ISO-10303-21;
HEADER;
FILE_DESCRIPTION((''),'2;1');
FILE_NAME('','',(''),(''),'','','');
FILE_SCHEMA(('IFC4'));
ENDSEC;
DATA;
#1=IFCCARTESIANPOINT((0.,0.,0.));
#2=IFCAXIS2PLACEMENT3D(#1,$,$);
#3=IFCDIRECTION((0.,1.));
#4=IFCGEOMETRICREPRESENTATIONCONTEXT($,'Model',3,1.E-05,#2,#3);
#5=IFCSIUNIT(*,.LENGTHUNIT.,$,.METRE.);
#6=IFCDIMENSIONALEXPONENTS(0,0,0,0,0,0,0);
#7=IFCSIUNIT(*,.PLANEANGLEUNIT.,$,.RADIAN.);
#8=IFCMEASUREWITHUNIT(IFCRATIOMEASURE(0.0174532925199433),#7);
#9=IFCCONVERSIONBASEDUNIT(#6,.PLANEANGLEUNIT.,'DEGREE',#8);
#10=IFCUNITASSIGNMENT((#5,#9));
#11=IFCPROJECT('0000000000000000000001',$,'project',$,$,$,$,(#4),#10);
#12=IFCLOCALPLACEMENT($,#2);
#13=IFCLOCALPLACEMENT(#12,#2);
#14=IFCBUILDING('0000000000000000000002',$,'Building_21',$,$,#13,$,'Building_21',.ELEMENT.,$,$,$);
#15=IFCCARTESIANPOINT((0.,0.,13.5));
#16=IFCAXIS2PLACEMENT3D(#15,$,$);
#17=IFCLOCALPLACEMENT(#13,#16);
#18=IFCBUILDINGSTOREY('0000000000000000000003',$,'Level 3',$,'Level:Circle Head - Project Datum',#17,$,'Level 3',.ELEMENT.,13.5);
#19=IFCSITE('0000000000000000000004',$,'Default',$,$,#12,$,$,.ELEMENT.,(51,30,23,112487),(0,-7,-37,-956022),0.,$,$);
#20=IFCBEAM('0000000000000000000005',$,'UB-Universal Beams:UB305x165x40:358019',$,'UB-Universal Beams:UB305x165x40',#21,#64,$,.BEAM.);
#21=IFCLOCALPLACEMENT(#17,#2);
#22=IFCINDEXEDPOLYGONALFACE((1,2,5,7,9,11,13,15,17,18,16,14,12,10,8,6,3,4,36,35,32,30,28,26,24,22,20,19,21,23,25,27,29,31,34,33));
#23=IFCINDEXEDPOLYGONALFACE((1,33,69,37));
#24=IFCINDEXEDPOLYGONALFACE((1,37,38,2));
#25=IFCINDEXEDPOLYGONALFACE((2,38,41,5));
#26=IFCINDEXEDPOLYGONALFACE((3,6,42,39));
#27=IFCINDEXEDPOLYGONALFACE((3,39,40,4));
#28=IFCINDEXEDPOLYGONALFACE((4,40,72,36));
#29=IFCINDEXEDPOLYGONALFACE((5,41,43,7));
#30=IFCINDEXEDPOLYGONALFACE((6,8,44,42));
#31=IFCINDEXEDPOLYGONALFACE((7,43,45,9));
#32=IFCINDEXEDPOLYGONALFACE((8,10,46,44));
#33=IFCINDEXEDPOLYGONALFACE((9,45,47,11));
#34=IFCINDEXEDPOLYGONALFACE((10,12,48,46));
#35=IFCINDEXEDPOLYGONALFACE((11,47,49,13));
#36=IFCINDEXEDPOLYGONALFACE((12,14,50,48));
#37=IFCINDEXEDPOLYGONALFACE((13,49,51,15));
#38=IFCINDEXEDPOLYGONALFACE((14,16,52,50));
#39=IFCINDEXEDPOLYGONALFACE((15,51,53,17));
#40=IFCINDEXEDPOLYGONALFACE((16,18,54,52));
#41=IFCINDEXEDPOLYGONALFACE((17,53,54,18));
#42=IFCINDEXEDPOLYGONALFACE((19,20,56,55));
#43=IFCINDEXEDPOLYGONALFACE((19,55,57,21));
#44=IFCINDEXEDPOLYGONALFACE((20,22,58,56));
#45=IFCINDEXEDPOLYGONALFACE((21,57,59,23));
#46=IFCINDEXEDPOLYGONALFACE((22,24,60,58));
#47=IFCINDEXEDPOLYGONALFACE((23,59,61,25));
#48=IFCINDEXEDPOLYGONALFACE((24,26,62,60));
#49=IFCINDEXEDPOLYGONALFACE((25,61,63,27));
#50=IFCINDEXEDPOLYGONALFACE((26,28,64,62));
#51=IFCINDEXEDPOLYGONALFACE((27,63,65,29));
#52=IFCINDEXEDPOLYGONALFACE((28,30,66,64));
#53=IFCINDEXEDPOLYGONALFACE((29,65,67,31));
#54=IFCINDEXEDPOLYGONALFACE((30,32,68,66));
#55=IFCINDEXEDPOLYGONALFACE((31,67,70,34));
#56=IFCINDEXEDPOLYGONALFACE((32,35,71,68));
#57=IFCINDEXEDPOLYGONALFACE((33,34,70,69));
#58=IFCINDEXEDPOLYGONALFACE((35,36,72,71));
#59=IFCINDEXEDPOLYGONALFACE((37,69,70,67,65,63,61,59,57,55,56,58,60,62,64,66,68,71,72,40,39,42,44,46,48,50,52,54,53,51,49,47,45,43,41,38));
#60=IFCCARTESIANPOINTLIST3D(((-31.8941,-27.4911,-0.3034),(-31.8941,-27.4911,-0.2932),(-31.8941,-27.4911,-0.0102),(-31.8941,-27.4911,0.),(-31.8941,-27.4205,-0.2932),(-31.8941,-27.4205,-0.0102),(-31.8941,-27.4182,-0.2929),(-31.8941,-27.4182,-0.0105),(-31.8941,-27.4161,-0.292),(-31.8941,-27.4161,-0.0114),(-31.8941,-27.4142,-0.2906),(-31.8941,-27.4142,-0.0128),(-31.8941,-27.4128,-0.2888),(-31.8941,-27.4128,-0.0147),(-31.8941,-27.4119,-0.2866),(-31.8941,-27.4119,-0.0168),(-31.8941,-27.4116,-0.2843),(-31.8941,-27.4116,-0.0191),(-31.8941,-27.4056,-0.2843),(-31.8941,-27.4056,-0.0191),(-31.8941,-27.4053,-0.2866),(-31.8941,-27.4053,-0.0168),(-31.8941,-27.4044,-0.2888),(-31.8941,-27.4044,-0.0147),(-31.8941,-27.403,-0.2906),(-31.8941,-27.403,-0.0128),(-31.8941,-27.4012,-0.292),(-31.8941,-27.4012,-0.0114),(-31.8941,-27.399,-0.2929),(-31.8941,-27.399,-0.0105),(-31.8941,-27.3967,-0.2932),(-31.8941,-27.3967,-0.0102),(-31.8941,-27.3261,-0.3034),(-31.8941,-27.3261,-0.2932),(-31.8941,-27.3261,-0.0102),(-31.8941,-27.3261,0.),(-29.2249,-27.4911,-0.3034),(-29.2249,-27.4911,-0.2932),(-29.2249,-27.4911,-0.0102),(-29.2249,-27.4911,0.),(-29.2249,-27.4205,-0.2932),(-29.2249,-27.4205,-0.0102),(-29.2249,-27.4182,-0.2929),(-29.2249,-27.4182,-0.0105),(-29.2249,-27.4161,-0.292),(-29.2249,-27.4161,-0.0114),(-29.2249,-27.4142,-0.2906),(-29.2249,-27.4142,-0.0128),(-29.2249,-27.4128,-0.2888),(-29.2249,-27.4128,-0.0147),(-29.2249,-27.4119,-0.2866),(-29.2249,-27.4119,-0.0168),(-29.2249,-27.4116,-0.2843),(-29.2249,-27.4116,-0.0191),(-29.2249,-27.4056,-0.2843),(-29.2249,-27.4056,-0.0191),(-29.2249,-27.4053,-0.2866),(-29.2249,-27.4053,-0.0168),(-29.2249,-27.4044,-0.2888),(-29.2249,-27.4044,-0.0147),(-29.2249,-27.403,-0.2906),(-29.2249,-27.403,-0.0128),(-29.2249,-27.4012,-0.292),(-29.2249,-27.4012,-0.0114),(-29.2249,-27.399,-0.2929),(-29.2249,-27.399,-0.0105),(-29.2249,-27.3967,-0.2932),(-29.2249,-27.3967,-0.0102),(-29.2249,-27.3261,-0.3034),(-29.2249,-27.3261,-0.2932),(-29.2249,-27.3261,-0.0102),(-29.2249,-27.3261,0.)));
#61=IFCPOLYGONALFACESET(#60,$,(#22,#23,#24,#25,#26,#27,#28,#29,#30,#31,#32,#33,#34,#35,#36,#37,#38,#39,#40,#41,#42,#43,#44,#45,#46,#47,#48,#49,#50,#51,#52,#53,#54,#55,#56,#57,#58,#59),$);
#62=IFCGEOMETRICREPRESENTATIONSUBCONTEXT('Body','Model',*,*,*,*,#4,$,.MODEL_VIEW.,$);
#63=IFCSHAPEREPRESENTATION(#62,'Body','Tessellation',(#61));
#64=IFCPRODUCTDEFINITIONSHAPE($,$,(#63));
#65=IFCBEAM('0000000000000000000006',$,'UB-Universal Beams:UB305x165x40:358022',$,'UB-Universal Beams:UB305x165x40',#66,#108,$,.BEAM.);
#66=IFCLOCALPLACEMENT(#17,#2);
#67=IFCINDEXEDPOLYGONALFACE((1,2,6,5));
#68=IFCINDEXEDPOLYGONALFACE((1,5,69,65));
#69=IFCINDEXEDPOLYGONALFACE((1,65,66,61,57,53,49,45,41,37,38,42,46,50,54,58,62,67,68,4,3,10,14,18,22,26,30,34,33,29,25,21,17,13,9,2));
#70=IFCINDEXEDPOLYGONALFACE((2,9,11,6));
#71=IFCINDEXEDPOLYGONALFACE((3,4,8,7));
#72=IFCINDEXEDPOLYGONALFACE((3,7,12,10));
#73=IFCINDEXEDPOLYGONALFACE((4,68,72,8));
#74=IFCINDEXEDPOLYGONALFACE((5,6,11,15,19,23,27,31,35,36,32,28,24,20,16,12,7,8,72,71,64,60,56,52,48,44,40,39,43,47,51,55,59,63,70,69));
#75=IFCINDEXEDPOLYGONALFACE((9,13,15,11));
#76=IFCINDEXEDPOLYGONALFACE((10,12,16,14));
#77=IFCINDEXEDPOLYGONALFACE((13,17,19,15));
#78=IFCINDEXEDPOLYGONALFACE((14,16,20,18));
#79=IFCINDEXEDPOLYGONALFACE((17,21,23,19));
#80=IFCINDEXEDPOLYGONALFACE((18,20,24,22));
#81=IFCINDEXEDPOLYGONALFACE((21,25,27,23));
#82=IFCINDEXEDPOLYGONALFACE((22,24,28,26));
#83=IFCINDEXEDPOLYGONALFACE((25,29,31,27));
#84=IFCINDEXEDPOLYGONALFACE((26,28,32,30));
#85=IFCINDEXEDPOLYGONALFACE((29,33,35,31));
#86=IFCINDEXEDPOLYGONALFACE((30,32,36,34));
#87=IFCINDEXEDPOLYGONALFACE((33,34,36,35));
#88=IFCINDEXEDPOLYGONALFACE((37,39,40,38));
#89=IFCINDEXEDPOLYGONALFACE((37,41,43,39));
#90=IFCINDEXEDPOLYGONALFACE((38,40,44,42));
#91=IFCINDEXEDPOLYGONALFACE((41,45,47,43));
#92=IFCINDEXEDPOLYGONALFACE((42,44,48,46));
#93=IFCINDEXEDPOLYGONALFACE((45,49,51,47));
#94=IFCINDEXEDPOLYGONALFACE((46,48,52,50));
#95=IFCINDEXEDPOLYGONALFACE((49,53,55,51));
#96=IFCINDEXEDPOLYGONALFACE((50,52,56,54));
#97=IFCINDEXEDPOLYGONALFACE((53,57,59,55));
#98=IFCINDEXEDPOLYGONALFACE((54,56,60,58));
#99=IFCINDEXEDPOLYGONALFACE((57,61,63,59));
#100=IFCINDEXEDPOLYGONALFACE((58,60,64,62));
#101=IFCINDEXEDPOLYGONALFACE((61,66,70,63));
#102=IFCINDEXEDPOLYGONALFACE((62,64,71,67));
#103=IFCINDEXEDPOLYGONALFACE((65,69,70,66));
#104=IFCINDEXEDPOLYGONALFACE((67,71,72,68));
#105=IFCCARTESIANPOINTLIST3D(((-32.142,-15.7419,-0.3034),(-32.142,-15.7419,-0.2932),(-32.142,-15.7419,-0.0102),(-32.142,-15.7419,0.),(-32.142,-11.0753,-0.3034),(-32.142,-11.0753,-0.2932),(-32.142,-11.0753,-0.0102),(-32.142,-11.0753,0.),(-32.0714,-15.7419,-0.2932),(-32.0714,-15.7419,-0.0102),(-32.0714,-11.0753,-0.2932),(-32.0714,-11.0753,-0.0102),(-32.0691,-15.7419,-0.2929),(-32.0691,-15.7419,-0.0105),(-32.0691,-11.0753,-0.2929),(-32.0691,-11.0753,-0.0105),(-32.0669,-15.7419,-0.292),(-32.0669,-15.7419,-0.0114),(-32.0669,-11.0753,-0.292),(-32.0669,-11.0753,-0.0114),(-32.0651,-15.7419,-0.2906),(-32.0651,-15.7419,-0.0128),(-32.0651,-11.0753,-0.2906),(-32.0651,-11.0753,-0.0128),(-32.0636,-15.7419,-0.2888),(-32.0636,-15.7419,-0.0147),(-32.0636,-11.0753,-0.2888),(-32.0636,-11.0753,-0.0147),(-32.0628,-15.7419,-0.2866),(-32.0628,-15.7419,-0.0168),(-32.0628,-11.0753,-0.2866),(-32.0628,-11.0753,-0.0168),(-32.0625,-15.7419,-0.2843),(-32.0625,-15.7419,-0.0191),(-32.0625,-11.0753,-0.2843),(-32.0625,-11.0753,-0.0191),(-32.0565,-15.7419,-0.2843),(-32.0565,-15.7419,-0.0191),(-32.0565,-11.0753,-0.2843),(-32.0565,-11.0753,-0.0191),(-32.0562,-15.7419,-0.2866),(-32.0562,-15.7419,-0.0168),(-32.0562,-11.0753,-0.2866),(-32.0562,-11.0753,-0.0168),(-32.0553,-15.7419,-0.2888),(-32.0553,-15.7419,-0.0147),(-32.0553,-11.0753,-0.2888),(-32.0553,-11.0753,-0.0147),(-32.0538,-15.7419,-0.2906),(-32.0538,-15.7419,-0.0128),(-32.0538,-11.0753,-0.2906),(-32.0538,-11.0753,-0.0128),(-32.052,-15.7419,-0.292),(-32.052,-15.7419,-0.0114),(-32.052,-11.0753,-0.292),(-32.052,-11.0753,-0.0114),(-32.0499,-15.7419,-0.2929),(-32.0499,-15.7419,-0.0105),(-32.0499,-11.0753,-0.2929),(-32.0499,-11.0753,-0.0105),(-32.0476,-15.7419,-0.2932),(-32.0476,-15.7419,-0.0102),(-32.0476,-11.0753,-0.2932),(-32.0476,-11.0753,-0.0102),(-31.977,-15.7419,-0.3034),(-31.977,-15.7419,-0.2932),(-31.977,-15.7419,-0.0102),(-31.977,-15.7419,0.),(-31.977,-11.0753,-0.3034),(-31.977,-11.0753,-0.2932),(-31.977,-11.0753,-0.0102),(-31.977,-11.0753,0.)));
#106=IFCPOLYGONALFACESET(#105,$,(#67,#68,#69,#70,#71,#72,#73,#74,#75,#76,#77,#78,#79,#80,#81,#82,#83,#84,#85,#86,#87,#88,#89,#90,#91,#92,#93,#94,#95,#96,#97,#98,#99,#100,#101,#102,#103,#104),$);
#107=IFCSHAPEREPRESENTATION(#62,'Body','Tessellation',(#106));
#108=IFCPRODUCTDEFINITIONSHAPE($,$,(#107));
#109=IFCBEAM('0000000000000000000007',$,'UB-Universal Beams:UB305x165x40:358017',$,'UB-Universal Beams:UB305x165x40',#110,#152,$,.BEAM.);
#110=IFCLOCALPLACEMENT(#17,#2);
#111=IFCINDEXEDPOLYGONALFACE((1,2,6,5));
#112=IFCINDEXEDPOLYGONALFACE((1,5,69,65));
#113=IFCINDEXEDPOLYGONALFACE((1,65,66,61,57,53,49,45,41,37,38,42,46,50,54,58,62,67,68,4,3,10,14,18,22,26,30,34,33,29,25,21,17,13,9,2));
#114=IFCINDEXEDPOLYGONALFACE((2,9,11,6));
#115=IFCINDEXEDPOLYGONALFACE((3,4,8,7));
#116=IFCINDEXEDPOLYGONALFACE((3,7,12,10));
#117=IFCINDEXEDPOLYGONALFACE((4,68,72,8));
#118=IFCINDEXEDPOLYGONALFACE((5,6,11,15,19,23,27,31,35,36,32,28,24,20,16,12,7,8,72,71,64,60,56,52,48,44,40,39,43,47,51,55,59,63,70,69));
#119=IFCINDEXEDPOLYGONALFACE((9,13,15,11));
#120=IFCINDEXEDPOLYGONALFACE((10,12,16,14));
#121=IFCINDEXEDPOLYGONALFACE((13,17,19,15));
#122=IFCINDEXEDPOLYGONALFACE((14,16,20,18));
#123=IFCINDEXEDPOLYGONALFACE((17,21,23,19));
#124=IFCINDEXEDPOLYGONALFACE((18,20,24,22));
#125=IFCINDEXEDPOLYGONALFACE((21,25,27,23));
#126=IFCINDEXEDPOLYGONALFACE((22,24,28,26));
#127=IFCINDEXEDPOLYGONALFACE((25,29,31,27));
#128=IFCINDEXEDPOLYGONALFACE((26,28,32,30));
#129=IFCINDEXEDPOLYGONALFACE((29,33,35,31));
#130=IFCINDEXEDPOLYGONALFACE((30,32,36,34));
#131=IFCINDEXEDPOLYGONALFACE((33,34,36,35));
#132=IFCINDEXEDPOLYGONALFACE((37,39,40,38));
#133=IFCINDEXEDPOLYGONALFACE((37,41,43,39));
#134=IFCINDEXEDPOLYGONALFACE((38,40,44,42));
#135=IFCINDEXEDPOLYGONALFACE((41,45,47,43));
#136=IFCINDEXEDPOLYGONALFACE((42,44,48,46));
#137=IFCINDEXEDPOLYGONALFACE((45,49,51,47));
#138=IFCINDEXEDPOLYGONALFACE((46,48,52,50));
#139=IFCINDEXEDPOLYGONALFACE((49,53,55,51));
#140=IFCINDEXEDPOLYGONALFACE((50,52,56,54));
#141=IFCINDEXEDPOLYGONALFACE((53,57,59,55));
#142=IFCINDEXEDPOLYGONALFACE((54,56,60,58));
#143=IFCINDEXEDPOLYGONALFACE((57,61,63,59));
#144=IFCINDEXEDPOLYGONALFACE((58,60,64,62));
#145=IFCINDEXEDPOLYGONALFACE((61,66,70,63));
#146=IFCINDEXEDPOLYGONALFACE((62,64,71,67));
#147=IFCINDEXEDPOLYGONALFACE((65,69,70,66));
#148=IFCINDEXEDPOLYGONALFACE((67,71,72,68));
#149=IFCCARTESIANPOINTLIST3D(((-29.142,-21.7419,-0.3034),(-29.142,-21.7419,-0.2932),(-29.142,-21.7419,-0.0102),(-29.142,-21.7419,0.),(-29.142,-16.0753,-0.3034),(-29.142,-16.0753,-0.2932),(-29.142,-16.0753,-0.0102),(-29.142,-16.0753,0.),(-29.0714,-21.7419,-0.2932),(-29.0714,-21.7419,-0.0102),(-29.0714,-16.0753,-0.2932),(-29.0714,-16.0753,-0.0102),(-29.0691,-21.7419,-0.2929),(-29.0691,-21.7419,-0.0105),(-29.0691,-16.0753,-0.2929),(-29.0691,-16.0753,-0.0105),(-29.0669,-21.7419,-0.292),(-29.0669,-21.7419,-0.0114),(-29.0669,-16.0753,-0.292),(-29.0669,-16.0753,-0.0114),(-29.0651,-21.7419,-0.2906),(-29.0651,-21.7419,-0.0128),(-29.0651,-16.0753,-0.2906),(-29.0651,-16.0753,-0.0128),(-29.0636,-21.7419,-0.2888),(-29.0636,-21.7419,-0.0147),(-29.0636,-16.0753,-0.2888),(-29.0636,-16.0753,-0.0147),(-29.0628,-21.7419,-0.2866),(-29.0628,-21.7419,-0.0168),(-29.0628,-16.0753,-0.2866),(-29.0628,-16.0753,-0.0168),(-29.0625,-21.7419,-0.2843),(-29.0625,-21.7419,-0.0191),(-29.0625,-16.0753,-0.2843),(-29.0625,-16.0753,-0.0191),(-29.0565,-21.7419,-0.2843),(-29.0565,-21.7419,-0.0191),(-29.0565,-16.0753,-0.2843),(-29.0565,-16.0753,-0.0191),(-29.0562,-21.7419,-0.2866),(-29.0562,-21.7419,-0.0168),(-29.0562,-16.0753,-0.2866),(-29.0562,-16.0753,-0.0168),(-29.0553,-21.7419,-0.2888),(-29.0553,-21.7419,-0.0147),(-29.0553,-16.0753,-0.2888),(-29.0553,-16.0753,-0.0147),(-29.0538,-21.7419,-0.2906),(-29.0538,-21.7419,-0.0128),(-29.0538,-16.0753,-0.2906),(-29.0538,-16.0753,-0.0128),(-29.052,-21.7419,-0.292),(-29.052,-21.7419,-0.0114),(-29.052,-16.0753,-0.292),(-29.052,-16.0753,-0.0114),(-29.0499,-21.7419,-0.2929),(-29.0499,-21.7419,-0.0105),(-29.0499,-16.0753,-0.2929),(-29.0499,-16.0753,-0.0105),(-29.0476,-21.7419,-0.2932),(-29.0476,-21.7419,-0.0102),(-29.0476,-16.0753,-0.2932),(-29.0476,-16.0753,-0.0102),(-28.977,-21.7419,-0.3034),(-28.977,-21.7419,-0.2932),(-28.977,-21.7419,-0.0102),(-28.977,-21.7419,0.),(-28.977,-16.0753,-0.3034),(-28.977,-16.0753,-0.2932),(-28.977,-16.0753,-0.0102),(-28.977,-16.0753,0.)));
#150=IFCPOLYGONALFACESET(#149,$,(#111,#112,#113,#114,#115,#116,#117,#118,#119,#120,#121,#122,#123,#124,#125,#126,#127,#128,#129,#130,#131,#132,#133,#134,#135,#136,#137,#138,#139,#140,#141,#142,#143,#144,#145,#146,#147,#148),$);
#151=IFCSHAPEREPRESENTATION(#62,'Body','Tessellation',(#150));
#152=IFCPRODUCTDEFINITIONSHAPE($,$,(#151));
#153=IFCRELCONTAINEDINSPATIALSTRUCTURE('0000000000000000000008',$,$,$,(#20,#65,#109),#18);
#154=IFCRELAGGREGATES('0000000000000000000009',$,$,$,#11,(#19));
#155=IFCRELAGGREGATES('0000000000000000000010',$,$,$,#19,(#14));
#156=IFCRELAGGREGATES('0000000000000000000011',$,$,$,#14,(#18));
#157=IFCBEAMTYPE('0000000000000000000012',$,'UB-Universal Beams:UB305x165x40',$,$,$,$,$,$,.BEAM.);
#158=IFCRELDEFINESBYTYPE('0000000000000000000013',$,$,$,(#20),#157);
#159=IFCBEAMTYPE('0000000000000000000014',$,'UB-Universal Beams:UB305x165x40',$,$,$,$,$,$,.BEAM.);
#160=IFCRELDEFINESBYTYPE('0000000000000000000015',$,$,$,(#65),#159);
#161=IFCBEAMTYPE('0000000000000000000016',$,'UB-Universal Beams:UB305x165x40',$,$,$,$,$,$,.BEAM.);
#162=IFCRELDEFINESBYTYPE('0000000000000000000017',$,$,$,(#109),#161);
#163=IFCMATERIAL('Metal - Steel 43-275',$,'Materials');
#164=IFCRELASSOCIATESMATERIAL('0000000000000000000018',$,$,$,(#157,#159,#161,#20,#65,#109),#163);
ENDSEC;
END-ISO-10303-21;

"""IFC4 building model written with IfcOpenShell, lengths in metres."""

from ifc_helpers import new_model, entity, si_unit, converted_unit, direction, frame, frame_2d, origin, place, context, subcontext, project, spatial, polyline, circle_curve, parameter, trimmed, segment, composite_curve, i_section, outline, extrude, source, transform, mapped, material, material_profile, profile_set, profile_usage, type_object, type_shapes, element, save


model = new_model("IFC4")

# Units and contexts
model_context = context("Model", 3, precision=1e-05, world=origin(), true_north=direction((0.0, 1.0)))
body_context = subcontext(model_context, "Body", "Model", "MODEL_VIEW")
ifc_project = project(units=[si_unit("LENGTHUNIT", "METRE"), converted_unit("PLANEANGLEUNIT", "DEGREE", entity("IfcRatioMeasure", 0.0174532925199433), si_unit("PLANEANGLEUNIT", "RADIAN"), dimensions=[0, 0, 0, 0, 0, 0, 0])], contexts=[model_context])

# Site, building, storey
site_placement = place(None, origin())
site = spatial("IfcSite", under=ifc_project, at=site_placement, Name="Default", CompositionType="ELEMENT", RefLatitude=(51, 30, 23, 112487), RefLongitude=(0, -7, -37, -956022), RefElevation=0.0)
building_placement = place(site_placement, origin())
building = spatial("IfcBuilding", under=site, at=building_placement, Name="Building_21", LongName="Building_21", CompositionType="ELEMENT")
storey_placement = place(building_placement, frame((0.0, 0.0, 13.5)))
storey = spatial("IfcBuildingStorey", under=building, at=storey_placement, Name="Level 3", ObjectType="Level:Circle Head - Project Datum", LongName="Level 3", CompositionType="ELEMENT", Elevation=13.5)

# Shared definitions
ifc_material_1 = material(Name="Metal - Steel 43-275", Category="Materials")

# Beams
ifc_material_profile_1 = material_profile(ifc_material_1, outline(composite_curve([segment(polyline([(0.0119, -0.1415, 0.0), (0.0825, -0.1415, 0.0)]), True, "CONTINUOUS"), segment(polyline([(0.0825, -0.1415, 0.0), (0.0825, -0.1517, 0.0)]), True, "CONTINUOUS"), segment(polyline([(0.0825, -0.1517, 0.0), (-0.0825, -0.1517, 0.0)]), True, "CONTINUOUS"), segment(polyline([(-0.0825, -0.1517, 0.0), (-0.0825, -0.1415, 0.0)]), True, "CONTINUOUS"), segment(polyline([(-0.0825, -0.1415, 0.0), (-0.0119, -0.1415, 0.0)]), True, "CONTINUOUS"), segment(trimmed(circle_curve(frame((-0.0119, -0.1326, 0.0), z_axis=(0.0, 0.0, 1.0), x_axis=(-1.0, 0.0, 0.0)), 0.0089), [parameter(90.0)], [parameter(180.0)], True, "PARAMETER"), True, "CONTINUOUS"), segment(polyline([(-0.003, -0.1326, 0.0), (-0.003, 0.1326, 0.0)]), True, "CONTINUOUS"), segment(trimmed(circle_curve(frame((-0.0119, 0.1326, 0.0), z_axis=(0.0, 0.0, 1.0), x_axis=(-1.0, 0.0, 0.0)), 0.0089), [parameter(180.0)], [parameter(270.0)], True, "PARAMETER"), True, "CONTINUOUS"), segment(polyline([(-0.0119, 0.1415, 0.0), (-0.0825, 0.1415, 0.0)]), True, "CONTINUOUS"), segment(polyline([(-0.0825, 0.1415, 0.0), (-0.0825, 0.1517, 0.0)]), True, "CONTINUOUS"), segment(polyline([(-0.0825, 0.1517, 0.0), (0.0825, 0.1517, 0.0)]), True, "CONTINUOUS"), segment(polyline([(0.0825, 0.1517, 0.0), (0.0825, 0.1415, 0.0)]), True, "CONTINUOUS"), segment(polyline([(0.0825, 0.1415, 0.0), (0.0119, 0.1415, 0.0)]), True, "CONTINUOUS"), segment(trimmed(circle_curve(frame((0.0119, 0.1326, 0.0), z_axis=(0.0, 0.0, 1.0), x_axis=(-1.0, 0.0, 0.0)), 0.0089), [parameter(270.0)], [parameter(0.0)], True, "PARAMETER"), True, "CONTINUOUS"), segment(polyline([(0.003, 0.1326, 0.0), (0.003, -0.1326, 0.0)]), True, "CONTINUOUS"), segment(trimmed(circle_curve(frame((0.0119, -0.1326, 0.0), z_axis=(0.0, 0.0, 1.0), x_axis=(-1.0, 0.0, 0.0)), 0.0089), [parameter(0.0)], [parameter(90.0)], True, "PARAMETER"), True, "CONTINUOUS")], self_intersect=False), kind="CURVE"), Name="UB305x165x40")
ifc_material_profile_2 = material_profile(ifc_material_1, outline(composite_curve([segment(polyline([(-1.3346, 0.0825, -0.1415), (-1.3346, 0.0825, -0.1517)]), True, "CONTINUOUS"), segment(polyline([(-1.3346, 0.0825, -0.1517), (-1.3346, -0.0825, -0.1517)]), True, "CONTINUOUS"), segment(polyline([(-1.3346, -0.0825, -0.1517), (-1.3346, -0.0825, -0.1415)]), True, "CONTINUOUS"), segment(polyline([(-1.3346, -0.0825, -0.1415), (-1.3346, -0.003, -0.1415)]), True, "CONTINUOUS"), segment(polyline([(-1.3346, -0.003, -0.1415), (-1.3346, -0.003, 0.1415)]), True, "CONTINUOUS"), segment(polyline([(-1.3346, -0.003, 0.1415), (-1.3346, -0.0825, 0.1415)]), True, "CONTINUOUS"), segment(polyline([(-1.3346, -0.0825, 0.1415), (-1.3346, -0.0825, 0.1517)]), True, "CONTINUOUS"), segment(polyline([(-1.3346, -0.0825, 0.1517), (-1.3346, 0.0825, 0.1517)]), True, "CONTINUOUS"), segment(polyline([(-1.3346, 0.0825, 0.1517), (-1.3346, 0.0825, 0.1415)]), True, "CONTINUOUS"), segment(polyline([(-1.3346, 0.0825, 0.1415), (-1.3346, 0.003, 0.1415)]), True, "CONTINUOUS"), segment(polyline([(-1.3346, 0.003, 0.1415), (-1.3346, 0.003, -0.1415)]), True, "CONTINUOUS"), segment(polyline([(-1.3346, 0.003, -0.1415), (-1.3346, 0.0825, -0.1415)]), True, "CONTINUOUS")], self_intersect=False), kind="CURVE"), Name="UB305x165x40")
ifc_profile_set_1 = profile_set([ifc_material_profile_1, ifc_material_profile_2], Name="UB305x165x40")
ifc_profile_usage_1 = profile_usage(ifc_profile_set_1, cardinal=8)
beam_type_1 = type_object("IfcBeamType", Name="UB-Universal Beams:UB305x165x40", PredefinedType="BEAM", material=ifc_profile_set_1)
shared_shape_1 = source(origin(), body_context, "Body", "SweptSolid", [
    extrude(i_section(OverallWidth=0.165, OverallDepth=0.3034, WebThickness=0.006, FlangeThickness=0.0102, FilletRadius=0.0089, at=frame_2d((0.0, 0.0), x_axis=(0.0, 1.0))), frame((-1.3346, 0.0, 0.0), z_axis=(1.0, 0.0, 0.0), x_axis=(0.0, 0.0, -1.0)), (0.0, 0.0, 1.0), 2.6692),
])
type_shapes(beam_type_1, [shared_shape_1])
beam_1_placement = place(storey_placement, frame((-30.5595, -27.4086, -0.1517)))
element("IfcBeam", 1, at=beam_1_placement, inside=storey, type_object=beam_type_1, material=ifc_profile_usage_1, Name="UB-Universal Beams:UB305x165x40:358019", ObjectType="UB-Universal Beams:UB305x165x40", PredefinedType="BEAM", context=body_context, shape_type="MappedRepresentation", body=[
    mapped(shared_shape_1, transform((0.0, 0.0, 0.0), scale=1.0)),
])
ifc_profile_usage_2 = profile_usage(ifc_profile_set_1, cardinal=8)
beam_type_2 = type_object("IfcBeamType", Name="UB-Universal Beams:UB305x165x40", PredefinedType="BEAM", material=ifc_profile_set_1)
shared_shape_2 = source(origin(), body_context, "Body", "SweptSolid", [
    extrude(i_section(OverallWidth=0.165, OverallDepth=0.3034, WebThickness=0.006, FlangeThickness=0.0102, FilletRadius=0.0089, at=frame_2d((0.0, 0.0), x_axis=(0.0, 1.0))), frame((-2.3333, 0.0, 0.0), z_axis=(1.0, 0.0, 0.0), x_axis=(0.0, 0.0, -1.0)), (0.0, 0.0, 1.0), 4.6666),
])
type_shapes(beam_type_2, [shared_shape_2])
beam_2_placement = place(storey_placement, frame((-32.0595, -13.4086, -0.1517), z_axis=(0.0, 0.0, 1.0), x_axis=(0.0, -1.0, 0.0)))
element("IfcBeam", 2, at=beam_2_placement, inside=storey, type_object=beam_type_2, material=ifc_profile_usage_2, Name="UB-Universal Beams:UB305x165x40:358022", ObjectType="UB-Universal Beams:UB305x165x40", PredefinedType="BEAM", context=body_context, shape_type="MappedRepresentation", body=[
    mapped(shared_shape_2, transform((0.0, 0.0, 0.0), scale=1.0)),
])
ifc_profile_usage_3 = profile_usage(ifc_profile_set_1, cardinal=8)
beam_type_3 = type_object("IfcBeamType", Name="UB-Universal Beams:UB305x165x40", PredefinedType="BEAM", material=ifc_profile_set_1)
shared_shape_3 = source(origin(), body_context, "Body", "SweptSolid", [
    extrude(i_section(OverallWidth=0.165, OverallDepth=0.3034, WebThickness=0.006, FlangeThickness=0.0102, FilletRadius=0.0089, at=frame_2d((0.0, 0.0), x_axis=(0.0, 1.0))), frame((-2.8333, 0.0, 0.0), z_axis=(1.0, 0.0, 0.0), x_axis=(0.0, 0.0, -1.0)), (0.0, 0.0, 1.0), 5.6666),
])
type_shapes(beam_type_3, [shared_shape_3])
beam_3_placement = place(storey_placement, frame((-29.0595, -18.9086, -0.1517), z_axis=(0.0, 0.0, 1.0), x_axis=(0.0, 1.0, 0.0)))
element("IfcBeam", 3, at=beam_3_placement, inside=storey, type_object=beam_type_3, material=ifc_profile_usage_3, Name="UB-Universal Beams:UB305x165x40:358017", ObjectType="UB-Universal Beams:UB305x165x40", PredefinedType="BEAM", context=body_context, shape_type="MappedRepresentation", body=[
    mapped(shared_shape_3, transform((0.0, 0.0, 0.0), scale=1.0)),
])

save(model, "model.ifc")
